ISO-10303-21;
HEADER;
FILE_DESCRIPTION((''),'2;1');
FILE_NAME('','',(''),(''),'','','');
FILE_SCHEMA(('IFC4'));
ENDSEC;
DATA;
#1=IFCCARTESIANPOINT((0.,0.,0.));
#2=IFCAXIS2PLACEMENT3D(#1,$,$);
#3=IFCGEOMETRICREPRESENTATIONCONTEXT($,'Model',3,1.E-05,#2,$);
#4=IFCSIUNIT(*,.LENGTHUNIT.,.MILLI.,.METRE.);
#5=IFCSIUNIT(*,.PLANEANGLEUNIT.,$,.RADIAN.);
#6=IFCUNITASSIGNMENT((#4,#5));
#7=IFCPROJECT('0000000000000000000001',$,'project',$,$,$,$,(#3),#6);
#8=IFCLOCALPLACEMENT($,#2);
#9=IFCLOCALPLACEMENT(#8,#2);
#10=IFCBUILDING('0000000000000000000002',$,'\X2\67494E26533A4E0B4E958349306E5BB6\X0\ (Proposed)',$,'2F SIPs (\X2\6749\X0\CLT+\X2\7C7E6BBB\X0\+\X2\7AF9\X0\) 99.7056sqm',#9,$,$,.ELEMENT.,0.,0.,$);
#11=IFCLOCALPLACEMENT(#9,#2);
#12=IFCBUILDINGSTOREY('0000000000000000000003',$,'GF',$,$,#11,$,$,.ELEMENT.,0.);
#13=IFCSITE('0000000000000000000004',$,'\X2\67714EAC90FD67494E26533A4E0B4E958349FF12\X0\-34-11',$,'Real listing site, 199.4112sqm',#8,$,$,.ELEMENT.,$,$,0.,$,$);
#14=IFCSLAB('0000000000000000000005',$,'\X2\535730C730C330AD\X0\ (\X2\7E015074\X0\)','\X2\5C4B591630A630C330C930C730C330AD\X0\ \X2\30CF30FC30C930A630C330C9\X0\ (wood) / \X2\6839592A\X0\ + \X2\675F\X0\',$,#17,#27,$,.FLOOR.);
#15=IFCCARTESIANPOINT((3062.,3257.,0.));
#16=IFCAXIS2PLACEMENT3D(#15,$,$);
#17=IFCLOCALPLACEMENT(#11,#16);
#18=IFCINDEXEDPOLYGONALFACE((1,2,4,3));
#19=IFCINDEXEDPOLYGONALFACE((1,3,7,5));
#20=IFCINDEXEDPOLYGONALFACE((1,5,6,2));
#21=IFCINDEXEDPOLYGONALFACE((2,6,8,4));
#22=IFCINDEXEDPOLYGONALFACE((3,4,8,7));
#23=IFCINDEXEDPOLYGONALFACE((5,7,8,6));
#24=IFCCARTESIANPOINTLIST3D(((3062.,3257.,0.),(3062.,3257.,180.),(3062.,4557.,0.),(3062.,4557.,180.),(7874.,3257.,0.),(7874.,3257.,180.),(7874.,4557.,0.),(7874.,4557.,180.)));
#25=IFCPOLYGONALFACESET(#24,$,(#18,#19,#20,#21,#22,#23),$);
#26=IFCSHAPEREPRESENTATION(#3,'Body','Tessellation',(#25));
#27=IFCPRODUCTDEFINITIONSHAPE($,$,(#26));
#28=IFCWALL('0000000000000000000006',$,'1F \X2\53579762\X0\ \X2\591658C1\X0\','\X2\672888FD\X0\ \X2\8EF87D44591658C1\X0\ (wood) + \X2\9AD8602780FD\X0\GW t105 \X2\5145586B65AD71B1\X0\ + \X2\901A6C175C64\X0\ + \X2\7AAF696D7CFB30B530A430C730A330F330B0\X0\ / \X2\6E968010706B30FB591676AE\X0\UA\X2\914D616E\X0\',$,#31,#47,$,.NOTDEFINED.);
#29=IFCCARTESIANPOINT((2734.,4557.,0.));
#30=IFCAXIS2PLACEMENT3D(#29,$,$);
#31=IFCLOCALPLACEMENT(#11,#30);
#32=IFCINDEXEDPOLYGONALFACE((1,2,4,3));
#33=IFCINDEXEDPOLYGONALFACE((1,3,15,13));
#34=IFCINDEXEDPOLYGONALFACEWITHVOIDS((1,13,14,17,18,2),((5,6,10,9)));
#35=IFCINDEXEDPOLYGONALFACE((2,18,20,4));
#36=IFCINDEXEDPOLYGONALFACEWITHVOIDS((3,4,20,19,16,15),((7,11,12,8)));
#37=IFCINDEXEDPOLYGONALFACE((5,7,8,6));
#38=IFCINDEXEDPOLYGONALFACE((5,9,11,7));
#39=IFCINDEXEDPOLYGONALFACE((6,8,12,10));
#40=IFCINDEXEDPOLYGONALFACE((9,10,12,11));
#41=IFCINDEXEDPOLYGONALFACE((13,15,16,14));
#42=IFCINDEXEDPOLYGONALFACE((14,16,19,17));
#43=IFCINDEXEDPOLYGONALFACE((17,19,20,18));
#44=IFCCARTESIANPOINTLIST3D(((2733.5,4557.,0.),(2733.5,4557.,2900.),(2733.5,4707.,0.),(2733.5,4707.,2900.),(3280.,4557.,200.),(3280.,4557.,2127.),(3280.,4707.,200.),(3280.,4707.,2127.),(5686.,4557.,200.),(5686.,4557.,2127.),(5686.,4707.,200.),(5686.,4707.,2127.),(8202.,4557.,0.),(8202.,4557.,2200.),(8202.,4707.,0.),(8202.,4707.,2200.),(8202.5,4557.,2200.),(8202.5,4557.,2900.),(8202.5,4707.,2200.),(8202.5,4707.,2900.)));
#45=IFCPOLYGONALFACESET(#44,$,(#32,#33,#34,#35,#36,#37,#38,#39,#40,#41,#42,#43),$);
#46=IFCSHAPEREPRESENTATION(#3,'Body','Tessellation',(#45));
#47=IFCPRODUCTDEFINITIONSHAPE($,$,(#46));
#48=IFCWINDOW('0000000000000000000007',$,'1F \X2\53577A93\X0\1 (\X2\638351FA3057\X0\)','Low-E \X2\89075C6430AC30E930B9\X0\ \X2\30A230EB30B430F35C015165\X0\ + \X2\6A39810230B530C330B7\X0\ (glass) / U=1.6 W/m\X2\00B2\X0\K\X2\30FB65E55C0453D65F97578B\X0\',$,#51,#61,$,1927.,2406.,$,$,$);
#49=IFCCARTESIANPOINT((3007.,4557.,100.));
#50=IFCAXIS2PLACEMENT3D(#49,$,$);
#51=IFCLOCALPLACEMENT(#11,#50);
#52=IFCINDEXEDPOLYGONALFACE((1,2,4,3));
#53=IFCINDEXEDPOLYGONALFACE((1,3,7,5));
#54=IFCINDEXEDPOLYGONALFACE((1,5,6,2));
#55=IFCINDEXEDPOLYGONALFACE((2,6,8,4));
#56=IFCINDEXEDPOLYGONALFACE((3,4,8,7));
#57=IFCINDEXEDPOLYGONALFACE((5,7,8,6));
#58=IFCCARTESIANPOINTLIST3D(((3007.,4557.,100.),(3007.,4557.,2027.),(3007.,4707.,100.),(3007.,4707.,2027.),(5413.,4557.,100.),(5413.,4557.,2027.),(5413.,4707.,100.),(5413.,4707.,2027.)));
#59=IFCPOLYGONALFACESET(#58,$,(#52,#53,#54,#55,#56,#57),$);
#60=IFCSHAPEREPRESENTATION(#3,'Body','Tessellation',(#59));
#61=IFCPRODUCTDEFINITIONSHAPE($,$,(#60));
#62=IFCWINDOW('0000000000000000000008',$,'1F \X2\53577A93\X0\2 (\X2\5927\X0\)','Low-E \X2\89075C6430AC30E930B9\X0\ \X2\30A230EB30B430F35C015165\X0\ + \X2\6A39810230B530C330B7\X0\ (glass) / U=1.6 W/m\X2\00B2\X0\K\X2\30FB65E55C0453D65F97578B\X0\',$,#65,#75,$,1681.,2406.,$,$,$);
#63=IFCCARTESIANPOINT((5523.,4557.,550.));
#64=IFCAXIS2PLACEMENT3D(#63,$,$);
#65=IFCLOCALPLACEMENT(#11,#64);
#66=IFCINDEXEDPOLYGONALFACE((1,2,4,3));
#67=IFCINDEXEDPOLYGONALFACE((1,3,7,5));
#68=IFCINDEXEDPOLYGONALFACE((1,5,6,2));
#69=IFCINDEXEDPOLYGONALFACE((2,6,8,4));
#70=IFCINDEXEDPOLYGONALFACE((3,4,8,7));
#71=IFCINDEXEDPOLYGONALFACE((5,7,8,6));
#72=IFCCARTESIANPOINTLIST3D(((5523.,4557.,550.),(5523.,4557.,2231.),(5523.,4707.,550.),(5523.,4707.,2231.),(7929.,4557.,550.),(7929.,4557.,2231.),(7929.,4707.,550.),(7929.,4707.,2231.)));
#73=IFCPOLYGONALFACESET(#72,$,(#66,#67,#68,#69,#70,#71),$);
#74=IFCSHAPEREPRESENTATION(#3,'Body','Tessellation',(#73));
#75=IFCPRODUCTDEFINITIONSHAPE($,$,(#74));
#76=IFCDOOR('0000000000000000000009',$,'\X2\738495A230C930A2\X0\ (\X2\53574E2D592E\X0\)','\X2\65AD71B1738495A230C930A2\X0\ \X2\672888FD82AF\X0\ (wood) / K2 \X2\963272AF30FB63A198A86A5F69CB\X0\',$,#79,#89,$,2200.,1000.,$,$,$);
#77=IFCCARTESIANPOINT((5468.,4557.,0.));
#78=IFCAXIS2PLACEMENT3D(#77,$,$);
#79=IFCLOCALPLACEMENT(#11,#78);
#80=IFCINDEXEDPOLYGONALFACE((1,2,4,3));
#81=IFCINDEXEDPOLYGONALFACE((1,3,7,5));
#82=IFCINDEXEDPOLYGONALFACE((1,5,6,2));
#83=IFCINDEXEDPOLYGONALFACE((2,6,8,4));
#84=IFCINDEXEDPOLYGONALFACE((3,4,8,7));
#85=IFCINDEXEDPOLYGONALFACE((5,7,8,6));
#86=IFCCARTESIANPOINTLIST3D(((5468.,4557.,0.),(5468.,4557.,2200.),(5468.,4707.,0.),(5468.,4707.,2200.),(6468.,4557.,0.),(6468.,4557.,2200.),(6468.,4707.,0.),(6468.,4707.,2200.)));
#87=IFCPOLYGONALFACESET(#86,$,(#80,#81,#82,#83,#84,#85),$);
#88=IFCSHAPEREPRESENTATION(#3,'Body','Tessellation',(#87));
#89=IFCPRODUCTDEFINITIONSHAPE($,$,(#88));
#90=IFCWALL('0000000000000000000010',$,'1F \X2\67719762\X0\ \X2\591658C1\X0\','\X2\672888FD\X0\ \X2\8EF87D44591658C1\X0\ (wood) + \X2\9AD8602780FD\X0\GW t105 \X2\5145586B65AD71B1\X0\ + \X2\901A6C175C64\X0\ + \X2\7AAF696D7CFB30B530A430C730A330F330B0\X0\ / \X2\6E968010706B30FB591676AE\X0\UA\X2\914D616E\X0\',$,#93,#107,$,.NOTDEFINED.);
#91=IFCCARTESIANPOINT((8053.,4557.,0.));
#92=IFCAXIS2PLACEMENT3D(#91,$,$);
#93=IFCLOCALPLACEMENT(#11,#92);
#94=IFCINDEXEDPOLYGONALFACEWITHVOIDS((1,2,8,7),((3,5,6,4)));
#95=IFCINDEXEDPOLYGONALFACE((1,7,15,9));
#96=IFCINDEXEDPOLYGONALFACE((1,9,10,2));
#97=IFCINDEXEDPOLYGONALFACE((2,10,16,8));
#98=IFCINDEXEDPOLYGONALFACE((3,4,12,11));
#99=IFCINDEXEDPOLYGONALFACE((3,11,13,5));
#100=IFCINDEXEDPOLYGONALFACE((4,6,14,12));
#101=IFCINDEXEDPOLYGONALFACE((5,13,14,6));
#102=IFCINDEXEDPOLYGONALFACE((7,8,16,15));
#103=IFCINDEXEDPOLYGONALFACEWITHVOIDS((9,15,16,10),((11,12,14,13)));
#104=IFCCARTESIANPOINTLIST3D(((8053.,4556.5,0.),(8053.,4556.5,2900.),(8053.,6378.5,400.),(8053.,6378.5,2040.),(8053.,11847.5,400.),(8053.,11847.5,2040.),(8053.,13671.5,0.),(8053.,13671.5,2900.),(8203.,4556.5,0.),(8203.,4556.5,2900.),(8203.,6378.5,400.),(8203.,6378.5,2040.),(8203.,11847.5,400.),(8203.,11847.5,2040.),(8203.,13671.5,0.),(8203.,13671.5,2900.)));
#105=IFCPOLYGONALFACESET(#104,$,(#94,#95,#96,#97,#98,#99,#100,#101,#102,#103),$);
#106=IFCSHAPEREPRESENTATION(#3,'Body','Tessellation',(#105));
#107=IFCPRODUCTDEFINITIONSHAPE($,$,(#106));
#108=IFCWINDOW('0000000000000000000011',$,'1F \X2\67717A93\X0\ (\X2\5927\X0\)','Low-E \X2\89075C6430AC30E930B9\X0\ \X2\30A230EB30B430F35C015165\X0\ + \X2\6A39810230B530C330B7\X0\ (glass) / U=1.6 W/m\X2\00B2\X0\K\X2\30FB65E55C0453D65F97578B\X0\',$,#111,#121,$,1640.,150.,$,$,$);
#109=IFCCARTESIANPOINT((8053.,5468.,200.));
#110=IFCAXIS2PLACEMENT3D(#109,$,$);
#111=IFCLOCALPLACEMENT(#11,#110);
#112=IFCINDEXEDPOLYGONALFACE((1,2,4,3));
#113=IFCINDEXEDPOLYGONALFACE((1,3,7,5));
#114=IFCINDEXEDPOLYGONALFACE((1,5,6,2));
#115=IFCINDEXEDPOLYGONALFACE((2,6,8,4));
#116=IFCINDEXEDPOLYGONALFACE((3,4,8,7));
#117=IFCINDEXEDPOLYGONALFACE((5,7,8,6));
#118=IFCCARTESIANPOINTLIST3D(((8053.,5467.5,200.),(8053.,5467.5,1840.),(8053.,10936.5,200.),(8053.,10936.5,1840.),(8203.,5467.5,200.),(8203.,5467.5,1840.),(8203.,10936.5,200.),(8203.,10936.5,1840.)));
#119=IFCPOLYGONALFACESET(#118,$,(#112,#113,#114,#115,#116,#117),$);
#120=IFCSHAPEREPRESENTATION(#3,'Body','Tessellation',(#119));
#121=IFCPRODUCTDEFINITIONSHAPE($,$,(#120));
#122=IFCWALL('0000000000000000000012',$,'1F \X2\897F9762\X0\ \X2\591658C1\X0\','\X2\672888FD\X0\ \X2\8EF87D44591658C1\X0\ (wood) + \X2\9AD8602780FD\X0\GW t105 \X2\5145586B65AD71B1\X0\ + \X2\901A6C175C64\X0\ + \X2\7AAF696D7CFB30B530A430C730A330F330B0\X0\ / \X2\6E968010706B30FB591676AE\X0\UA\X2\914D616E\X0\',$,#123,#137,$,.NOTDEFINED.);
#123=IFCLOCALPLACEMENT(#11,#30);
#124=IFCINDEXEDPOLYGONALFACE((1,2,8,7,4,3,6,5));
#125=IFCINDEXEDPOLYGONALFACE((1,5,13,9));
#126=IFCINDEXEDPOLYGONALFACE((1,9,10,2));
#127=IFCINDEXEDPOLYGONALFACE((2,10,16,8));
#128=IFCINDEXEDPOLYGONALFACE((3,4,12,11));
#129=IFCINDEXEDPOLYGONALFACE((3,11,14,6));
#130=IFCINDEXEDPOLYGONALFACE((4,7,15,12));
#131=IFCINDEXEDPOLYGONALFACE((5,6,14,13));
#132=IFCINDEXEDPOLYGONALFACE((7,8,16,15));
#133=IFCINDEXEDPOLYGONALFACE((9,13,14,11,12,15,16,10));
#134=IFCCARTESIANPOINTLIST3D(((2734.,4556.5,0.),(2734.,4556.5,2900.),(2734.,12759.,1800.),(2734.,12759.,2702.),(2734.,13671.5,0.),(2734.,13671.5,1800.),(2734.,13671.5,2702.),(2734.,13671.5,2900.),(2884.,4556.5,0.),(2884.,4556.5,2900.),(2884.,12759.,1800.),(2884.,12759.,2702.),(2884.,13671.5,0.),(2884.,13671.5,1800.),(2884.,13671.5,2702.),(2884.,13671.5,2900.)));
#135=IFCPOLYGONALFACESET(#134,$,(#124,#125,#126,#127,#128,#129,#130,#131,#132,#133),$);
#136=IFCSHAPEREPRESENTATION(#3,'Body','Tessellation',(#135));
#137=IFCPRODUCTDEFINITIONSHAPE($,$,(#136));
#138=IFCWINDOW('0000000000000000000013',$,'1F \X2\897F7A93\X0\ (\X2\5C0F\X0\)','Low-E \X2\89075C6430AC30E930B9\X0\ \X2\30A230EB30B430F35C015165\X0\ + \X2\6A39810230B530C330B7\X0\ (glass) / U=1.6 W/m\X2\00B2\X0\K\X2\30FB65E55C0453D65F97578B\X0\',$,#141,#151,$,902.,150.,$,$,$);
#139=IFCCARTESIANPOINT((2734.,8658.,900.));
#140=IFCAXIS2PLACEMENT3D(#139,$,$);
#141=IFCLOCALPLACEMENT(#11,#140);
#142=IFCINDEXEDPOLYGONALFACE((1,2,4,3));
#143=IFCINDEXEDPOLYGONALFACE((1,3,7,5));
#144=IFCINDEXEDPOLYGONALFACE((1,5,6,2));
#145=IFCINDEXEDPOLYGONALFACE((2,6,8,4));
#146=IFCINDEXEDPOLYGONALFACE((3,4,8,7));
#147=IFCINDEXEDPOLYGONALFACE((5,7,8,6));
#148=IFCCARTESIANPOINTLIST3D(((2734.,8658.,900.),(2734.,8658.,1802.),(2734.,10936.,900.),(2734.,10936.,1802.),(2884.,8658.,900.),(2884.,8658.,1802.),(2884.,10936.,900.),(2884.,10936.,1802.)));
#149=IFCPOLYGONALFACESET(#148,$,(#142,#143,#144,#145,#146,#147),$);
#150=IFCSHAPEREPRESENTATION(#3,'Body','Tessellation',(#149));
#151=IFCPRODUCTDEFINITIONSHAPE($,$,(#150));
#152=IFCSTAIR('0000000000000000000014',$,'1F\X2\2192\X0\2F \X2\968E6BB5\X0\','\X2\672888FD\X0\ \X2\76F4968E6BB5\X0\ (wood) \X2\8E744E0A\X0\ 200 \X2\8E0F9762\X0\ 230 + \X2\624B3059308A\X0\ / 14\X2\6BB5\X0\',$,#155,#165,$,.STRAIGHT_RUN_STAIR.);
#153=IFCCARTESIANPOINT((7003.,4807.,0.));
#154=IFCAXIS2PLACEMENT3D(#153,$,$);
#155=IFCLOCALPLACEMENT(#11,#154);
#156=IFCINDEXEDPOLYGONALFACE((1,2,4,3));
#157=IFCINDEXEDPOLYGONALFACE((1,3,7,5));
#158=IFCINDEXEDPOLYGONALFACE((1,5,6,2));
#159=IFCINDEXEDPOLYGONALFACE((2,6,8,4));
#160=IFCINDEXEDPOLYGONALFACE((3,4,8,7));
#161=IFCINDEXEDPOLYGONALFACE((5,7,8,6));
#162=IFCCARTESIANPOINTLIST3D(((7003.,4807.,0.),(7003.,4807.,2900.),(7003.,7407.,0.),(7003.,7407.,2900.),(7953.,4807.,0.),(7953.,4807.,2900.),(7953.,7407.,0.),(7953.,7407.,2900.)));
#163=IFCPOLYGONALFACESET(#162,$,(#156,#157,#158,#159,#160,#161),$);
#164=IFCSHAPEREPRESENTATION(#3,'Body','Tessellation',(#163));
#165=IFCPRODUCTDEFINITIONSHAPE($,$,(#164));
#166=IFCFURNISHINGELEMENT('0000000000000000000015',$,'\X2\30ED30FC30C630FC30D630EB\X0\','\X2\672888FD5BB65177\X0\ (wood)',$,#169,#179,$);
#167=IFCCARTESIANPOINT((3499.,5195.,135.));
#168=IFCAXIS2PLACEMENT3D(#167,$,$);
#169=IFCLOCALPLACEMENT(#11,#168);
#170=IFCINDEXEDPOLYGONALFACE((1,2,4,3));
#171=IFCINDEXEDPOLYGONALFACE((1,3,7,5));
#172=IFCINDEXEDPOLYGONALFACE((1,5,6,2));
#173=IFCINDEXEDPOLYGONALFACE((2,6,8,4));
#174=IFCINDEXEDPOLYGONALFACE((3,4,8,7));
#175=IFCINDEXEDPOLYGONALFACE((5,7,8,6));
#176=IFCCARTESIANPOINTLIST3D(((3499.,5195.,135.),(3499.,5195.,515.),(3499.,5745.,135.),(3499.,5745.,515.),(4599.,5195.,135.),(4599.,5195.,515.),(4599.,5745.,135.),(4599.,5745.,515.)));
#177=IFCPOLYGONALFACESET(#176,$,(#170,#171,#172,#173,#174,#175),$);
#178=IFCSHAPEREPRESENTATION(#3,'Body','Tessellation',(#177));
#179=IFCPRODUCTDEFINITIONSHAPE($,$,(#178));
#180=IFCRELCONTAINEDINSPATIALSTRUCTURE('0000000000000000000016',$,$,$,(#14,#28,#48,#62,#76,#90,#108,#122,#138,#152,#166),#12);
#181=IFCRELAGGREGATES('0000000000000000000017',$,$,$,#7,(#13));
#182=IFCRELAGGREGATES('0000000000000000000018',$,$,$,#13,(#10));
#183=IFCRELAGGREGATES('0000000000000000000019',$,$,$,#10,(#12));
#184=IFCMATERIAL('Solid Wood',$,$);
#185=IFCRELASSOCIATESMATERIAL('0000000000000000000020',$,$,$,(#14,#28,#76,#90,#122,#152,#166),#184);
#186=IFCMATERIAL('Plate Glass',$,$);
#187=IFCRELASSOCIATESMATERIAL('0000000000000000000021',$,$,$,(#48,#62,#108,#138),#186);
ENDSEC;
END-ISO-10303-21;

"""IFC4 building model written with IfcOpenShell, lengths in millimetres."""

from ifc_helpers import new_model, si_unit, frame, frame_2d, origin, place, context, project, spatial, rectangle, extrude, material, element, fill, save


model = new_model("IFC4")

# Units and contexts
model_context = context("Model", 3, precision=1e-05, world=origin())
ifc_project = project(units=[si_unit("LENGTHUNIT", "METRE", prefix="MILLI"), si_unit("PLANEANGLEUNIT", "RADIAN")], contexts=[model_context])

# Site, building, storey
site_placement = place(None, origin())
site = spatial("IfcSite", under=ifc_project, at=site_placement, Name="東京都杉並区下井草２-34-11", ObjectType="Real listing site, 199.4112sqm", CompositionType="ELEMENT", RefElevation=0.0)
building_placement = place(site_placement, origin())
building = spatial("IfcBuilding", under=site, at=building_placement, Name="杉並区下井草の家 (Proposed)", ObjectType="2F SIPs (杉CLT+籾殻+竹) 99.7056sqm", CompositionType="ELEMENT", ElevationOfRefHeight=0.0, ElevationOfTerrain=0.0)
storey_placement = place(building_placement, origin())
storey = spatial("IfcBuildingStorey", under=building, at=storey_placement, Name="GF", CompositionType="ELEMENT", Elevation=0.0)

# Slab
ifc_material_1 = material(Name="Solid Wood")
slab_1_placement = place(storey_placement, frame((3062.0, 3257.0, 0.0)))
element("IfcSlab", 1, at=slab_1_placement, inside=storey, material=ifc_material_1, Name="南デッキ (縁側)", Description="屋外ウッドデッキ ハードウッド (wood) / 根太 + 束", PredefinedType="FLOOR", context=model_context, shape_type="SweptSolid", body=[
    extrude(rectangle(XDim=4812.0, YDim=1300.0, at=frame_2d((2406.0, 650.0))), frame((3062.0, 3257.0, 0.0)), (0.0, 0.0, 1.0), 180.0),
])

# Wall, openings, windows, door
wall_1_placement = place(storey_placement, frame((2734.0, 4557.0, 0.0)))
wall_1 = element("IfcWall", 2, at=wall_1_placement, inside=storey, material=ifc_material_1, Name="1F 南面 外壁", Description="木製 軸組外壁 (wood) + 高性能GW t105 充填断熱 + 通気層 + 窯業系サイディング / 準耐火・外皮UA配慮", PredefinedType="NOTDEFINED", context=model_context, shape_type="SweptSolid", body=[
    extrude(rectangle(XDim=5469.0, YDim=150.0, at=frame_2d((2734.0, 75.0))), frame((2734.0, 4557.0, 0.0)), (0.0, 0.0, 1.0), 2900.0),
])
opening_1_placement = place(storey_placement, frame((3007.0, 4557.0, 100.0)))
opening_1 = element("IfcOpeningElement", 3, at=opening_1_placement, cuts=wall_1, PredefinedType="NOTDEFINED", context=model_context, shape_type="SweptSolid", body=[
    extrude(rectangle(XDim=2406.0, YDim=150.0, at=frame_2d((1203.0, 75.0))), frame((3007.0, 4557.0, 100.0)), (0.0, 0.0, 1.0), 1927.0),
])
opening_2_placement = place(storey_placement, frame((5523.0, 4557.0, 550.0)))
opening_2 = element("IfcOpeningElement", 4, at=opening_2_placement, cuts=wall_1, PredefinedType="NOTDEFINED", context=model_context, shape_type="SweptSolid", body=[
    extrude(rectangle(XDim=2406.0, YDim=150.0, at=frame_2d((1203.0, 75.0))), frame((5523.0, 4557.0, 550.0)), (0.0, 0.0, 1.0), 1681.0),
])
opening_3_placement = place(storey_placement, frame((5468.0, 4557.0, 0.0)))
opening_3 = element("IfcOpeningElement", 5, at=opening_3_placement, cuts=wall_1, PredefinedType="NOTDEFINED", context=model_context, shape_type="SweptSolid", body=[
    extrude(rectangle(XDim=1000.0, YDim=150.0, at=frame_2d((500.0, 75.0))), frame((5468.0, 4557.0, 0.0)), (0.0, 0.0, 1.0), 2200.0),
])
ifc_material_2 = material(Name="Plate Glass")
window_1_placement = place(storey_placement, frame((3007.0, 4557.0, 100.0)))
window_1 = element("IfcWindow", 6, at=window_1_placement, inside=storey, material=ifc_material_2, Name="1F 南窓1 (掃出し)", Description="Low-E 複層ガラス アルゴン封入 + 樹脂サッシ (glass) / U=1.6 W/m²K・日射取得型", OverallHeight=1927.0, OverallWidth=2406.0, context=model_context, shape_type="SweptSolid", body=[
    extrude(rectangle(XDim=2406.0, YDim=150.0, at=frame_2d((1203.0, 75.0))), frame((3007.0, 4557.0, 100.0)), (0.0, 0.0, 1.0), 1927.0),
])
fill(opening_1, window_1)
window_2_placement = place(storey_placement, frame((5523.0, 4557.0, 550.0)))
window_2 = element("IfcWindow", 7, at=window_2_placement, inside=storey, material=ifc_material_2, Name="1F 南窓2 (大)", Description="Low-E 複層ガラス アルゴン封入 + 樹脂サッシ (glass) / U=1.6 W/m²K・日射取得型", OverallHeight=1681.0, OverallWidth=2406.0, context=model_context, shape_type="SweptSolid", body=[
    extrude(rectangle(XDim=2406.0, YDim=150.0, at=frame_2d((1203.0, 75.0))), frame((5523.0, 4557.0, 550.0)), (0.0, 0.0, 1.0), 1681.0),
])
fill(opening_2, window_2)
door_placement = place(storey_placement, frame((5468.0, 4557.0, 0.0)))
door = element("IfcDoor", 8, at=door_placement, inside=storey, material=ifc_material_1, Name="玄関ドア (南中央)", Description="断熱玄関ドア 木製芯 (wood) / K2 防犯・採風機構", OverallHeight=2200.0, OverallWidth=1000.0, context=model_context, shape_type="SweptSolid", body=[
    extrude(rectangle(XDim=1000.0, YDim=150.0, at=frame_2d((500.0, 75.0))), frame((5468.0, 4557.0, 0.0)), (0.0, 0.0, 1.0), 2200.0),
])
fill(opening_3, door)

# Walls, openings, windows
wall_2_placement = place(storey_placement, frame((8053.0, 4557.0, 0.0)))
wall_2 = element("IfcWall", 9, at=wall_2_placement, inside=storey, material=ifc_material_1, Name="1F 東面 外壁", Description="木製 軸組外壁 (wood) + 高性能GW t105 充填断熱 + 通気層 + 窯業系サイディング / 準耐火・外皮UA配慮", PredefinedType="NOTDEFINED", context=model_context, shape_type="SweptSolid", body=[
    extrude(rectangle(XDim=150.0, YDim=9115.0, at=frame_2d((75.0, 4557.0))), frame((8053.0, 4557.0, 0.0)), (0.0, 0.0, 1.0), 2900.0),
])
opening_4_placement = place(storey_placement, frame((8053.0, 5468.0, 200.0)))
opening_4 = element("IfcOpeningElement", 10, at=opening_4_placement, cuts=wall_2, PredefinedType="NOTDEFINED", context=model_context, shape_type="SweptSolid", body=[
    extrude(rectangle(XDim=150.0, YDim=5469.0, at=frame_2d((75.0, 2734.0))), frame((8053.0, 5468.0, 200.0)), (0.0, 0.0, 1.0), 1640.0),
])
window_3_placement = place(storey_placement, frame((8053.0, 5468.0, 200.0)))
window_3 = element("IfcWindow", 11, at=window_3_placement, inside=storey, material=ifc_material_2, Name="1F 東窓 (大)", Description="Low-E 複層ガラス アルゴン封入 + 樹脂サッシ (glass) / U=1.6 W/m²K・日射取得型", OverallHeight=1640.0, OverallWidth=150.0, context=model_context, shape_type="SweptSolid", body=[
    extrude(rectangle(XDim=150.0, YDim=5469.0, at=frame_2d((75.0, 2734.0))), frame((8053.0, 5468.0, 200.0)), (0.0, 0.0, 1.0), 1640.0),
])
fill(opening_4, window_3)
wall_3_placement = place(storey_placement, frame((2734.0, 4557.0, 0.0)))
wall_3 = element("IfcWall", 12, at=wall_3_placement, inside=storey, material=ifc_material_1, Name="1F 西面 外壁", Description="木製 軸組外壁 (wood) + 高性能GW t105 充填断熱 + 通気層 + 窯業系サイディング / 準耐火・外皮UA配慮", PredefinedType="NOTDEFINED", context=model_context, shape_type="SweptSolid", body=[
    extrude(rectangle(XDim=150.0, YDim=9115.0, at=frame_2d((75.0, 4557.0))), frame((2734.0, 4557.0, 0.0)), (0.0, 0.0, 1.0), 2900.0),
])
opening_5_placement = place(storey_placement, frame((2734.0, 8658.0, 900.0)))
opening_5 = element("IfcOpeningElement", 13, at=opening_5_placement, cuts=wall_3, PredefinedType="NOTDEFINED", context=model_context, shape_type="SweptSolid", body=[
    extrude(rectangle(XDim=150.0, YDim=2278.0, at=frame_2d((75.0, 1139.0))), frame((2734.0, 8658.0, 900.0)), (0.0, 0.0, 1.0), 902.0),
])
window_4_placement = place(storey_placement, frame((2734.0, 8658.0, 900.0)))
window_4 = element("IfcWindow", 14, at=window_4_placement, inside=storey, material=ifc_material_2, Name="1F 西窓 (小)", Description="Low-E 複層ガラス アルゴン封入 + 樹脂サッシ (glass) / U=1.6 W/m²K・日射取得型", OverallHeight=902.0, OverallWidth=150.0, context=model_context, shape_type="SweptSolid", body=[
    extrude(rectangle(XDim=150.0, YDim=2278.0, at=frame_2d((75.0, 1139.0))), frame((2734.0, 8658.0, 900.0)), (0.0, 0.0, 1.0), 902.0),
])
fill(opening_5, window_4)

# Stair
stair_placement = place(storey_placement, frame((7003.0, 4807.0, 0.0)))
element("IfcStair", 15, at=stair_placement, inside=storey, material=ifc_material_1, Name="1F→2F 階段", Description="木製 直階段 (wood) 蹴上 200 踏面 230 + 手すり / 14段", PredefinedType="STRAIGHT_RUN_STAIR", context=model_context, shape_type="SweptSolid", body=[
    extrude(rectangle(XDim=950.0, YDim=2600.0, at=frame_2d((475.0, 1300.0))), frame((7003.0, 4807.0, 0.0)), (0.0, 0.0, 1.0), 2900.0),
])

# Furnishing element
furnishing_1_placement = place(storey_placement, frame((3499.0, 5195.0, 135.0)))
element("IfcFurnishingElement", 16, at=furnishing_1_placement, inside=storey, material=ifc_material_1, Name="ローテーブル", Description="木製家具 (wood)", context=model_context, shape_type="SweptSolid", body=[
    extrude(rectangle(XDim=1100.0, YDim=550.0, at=frame_2d((550.0, 275.0))), frame((3499.0, 5195.0, 135.0)), (0.0, 0.0, 1.0), 380.0),
])

save(model, "model.ifc")
